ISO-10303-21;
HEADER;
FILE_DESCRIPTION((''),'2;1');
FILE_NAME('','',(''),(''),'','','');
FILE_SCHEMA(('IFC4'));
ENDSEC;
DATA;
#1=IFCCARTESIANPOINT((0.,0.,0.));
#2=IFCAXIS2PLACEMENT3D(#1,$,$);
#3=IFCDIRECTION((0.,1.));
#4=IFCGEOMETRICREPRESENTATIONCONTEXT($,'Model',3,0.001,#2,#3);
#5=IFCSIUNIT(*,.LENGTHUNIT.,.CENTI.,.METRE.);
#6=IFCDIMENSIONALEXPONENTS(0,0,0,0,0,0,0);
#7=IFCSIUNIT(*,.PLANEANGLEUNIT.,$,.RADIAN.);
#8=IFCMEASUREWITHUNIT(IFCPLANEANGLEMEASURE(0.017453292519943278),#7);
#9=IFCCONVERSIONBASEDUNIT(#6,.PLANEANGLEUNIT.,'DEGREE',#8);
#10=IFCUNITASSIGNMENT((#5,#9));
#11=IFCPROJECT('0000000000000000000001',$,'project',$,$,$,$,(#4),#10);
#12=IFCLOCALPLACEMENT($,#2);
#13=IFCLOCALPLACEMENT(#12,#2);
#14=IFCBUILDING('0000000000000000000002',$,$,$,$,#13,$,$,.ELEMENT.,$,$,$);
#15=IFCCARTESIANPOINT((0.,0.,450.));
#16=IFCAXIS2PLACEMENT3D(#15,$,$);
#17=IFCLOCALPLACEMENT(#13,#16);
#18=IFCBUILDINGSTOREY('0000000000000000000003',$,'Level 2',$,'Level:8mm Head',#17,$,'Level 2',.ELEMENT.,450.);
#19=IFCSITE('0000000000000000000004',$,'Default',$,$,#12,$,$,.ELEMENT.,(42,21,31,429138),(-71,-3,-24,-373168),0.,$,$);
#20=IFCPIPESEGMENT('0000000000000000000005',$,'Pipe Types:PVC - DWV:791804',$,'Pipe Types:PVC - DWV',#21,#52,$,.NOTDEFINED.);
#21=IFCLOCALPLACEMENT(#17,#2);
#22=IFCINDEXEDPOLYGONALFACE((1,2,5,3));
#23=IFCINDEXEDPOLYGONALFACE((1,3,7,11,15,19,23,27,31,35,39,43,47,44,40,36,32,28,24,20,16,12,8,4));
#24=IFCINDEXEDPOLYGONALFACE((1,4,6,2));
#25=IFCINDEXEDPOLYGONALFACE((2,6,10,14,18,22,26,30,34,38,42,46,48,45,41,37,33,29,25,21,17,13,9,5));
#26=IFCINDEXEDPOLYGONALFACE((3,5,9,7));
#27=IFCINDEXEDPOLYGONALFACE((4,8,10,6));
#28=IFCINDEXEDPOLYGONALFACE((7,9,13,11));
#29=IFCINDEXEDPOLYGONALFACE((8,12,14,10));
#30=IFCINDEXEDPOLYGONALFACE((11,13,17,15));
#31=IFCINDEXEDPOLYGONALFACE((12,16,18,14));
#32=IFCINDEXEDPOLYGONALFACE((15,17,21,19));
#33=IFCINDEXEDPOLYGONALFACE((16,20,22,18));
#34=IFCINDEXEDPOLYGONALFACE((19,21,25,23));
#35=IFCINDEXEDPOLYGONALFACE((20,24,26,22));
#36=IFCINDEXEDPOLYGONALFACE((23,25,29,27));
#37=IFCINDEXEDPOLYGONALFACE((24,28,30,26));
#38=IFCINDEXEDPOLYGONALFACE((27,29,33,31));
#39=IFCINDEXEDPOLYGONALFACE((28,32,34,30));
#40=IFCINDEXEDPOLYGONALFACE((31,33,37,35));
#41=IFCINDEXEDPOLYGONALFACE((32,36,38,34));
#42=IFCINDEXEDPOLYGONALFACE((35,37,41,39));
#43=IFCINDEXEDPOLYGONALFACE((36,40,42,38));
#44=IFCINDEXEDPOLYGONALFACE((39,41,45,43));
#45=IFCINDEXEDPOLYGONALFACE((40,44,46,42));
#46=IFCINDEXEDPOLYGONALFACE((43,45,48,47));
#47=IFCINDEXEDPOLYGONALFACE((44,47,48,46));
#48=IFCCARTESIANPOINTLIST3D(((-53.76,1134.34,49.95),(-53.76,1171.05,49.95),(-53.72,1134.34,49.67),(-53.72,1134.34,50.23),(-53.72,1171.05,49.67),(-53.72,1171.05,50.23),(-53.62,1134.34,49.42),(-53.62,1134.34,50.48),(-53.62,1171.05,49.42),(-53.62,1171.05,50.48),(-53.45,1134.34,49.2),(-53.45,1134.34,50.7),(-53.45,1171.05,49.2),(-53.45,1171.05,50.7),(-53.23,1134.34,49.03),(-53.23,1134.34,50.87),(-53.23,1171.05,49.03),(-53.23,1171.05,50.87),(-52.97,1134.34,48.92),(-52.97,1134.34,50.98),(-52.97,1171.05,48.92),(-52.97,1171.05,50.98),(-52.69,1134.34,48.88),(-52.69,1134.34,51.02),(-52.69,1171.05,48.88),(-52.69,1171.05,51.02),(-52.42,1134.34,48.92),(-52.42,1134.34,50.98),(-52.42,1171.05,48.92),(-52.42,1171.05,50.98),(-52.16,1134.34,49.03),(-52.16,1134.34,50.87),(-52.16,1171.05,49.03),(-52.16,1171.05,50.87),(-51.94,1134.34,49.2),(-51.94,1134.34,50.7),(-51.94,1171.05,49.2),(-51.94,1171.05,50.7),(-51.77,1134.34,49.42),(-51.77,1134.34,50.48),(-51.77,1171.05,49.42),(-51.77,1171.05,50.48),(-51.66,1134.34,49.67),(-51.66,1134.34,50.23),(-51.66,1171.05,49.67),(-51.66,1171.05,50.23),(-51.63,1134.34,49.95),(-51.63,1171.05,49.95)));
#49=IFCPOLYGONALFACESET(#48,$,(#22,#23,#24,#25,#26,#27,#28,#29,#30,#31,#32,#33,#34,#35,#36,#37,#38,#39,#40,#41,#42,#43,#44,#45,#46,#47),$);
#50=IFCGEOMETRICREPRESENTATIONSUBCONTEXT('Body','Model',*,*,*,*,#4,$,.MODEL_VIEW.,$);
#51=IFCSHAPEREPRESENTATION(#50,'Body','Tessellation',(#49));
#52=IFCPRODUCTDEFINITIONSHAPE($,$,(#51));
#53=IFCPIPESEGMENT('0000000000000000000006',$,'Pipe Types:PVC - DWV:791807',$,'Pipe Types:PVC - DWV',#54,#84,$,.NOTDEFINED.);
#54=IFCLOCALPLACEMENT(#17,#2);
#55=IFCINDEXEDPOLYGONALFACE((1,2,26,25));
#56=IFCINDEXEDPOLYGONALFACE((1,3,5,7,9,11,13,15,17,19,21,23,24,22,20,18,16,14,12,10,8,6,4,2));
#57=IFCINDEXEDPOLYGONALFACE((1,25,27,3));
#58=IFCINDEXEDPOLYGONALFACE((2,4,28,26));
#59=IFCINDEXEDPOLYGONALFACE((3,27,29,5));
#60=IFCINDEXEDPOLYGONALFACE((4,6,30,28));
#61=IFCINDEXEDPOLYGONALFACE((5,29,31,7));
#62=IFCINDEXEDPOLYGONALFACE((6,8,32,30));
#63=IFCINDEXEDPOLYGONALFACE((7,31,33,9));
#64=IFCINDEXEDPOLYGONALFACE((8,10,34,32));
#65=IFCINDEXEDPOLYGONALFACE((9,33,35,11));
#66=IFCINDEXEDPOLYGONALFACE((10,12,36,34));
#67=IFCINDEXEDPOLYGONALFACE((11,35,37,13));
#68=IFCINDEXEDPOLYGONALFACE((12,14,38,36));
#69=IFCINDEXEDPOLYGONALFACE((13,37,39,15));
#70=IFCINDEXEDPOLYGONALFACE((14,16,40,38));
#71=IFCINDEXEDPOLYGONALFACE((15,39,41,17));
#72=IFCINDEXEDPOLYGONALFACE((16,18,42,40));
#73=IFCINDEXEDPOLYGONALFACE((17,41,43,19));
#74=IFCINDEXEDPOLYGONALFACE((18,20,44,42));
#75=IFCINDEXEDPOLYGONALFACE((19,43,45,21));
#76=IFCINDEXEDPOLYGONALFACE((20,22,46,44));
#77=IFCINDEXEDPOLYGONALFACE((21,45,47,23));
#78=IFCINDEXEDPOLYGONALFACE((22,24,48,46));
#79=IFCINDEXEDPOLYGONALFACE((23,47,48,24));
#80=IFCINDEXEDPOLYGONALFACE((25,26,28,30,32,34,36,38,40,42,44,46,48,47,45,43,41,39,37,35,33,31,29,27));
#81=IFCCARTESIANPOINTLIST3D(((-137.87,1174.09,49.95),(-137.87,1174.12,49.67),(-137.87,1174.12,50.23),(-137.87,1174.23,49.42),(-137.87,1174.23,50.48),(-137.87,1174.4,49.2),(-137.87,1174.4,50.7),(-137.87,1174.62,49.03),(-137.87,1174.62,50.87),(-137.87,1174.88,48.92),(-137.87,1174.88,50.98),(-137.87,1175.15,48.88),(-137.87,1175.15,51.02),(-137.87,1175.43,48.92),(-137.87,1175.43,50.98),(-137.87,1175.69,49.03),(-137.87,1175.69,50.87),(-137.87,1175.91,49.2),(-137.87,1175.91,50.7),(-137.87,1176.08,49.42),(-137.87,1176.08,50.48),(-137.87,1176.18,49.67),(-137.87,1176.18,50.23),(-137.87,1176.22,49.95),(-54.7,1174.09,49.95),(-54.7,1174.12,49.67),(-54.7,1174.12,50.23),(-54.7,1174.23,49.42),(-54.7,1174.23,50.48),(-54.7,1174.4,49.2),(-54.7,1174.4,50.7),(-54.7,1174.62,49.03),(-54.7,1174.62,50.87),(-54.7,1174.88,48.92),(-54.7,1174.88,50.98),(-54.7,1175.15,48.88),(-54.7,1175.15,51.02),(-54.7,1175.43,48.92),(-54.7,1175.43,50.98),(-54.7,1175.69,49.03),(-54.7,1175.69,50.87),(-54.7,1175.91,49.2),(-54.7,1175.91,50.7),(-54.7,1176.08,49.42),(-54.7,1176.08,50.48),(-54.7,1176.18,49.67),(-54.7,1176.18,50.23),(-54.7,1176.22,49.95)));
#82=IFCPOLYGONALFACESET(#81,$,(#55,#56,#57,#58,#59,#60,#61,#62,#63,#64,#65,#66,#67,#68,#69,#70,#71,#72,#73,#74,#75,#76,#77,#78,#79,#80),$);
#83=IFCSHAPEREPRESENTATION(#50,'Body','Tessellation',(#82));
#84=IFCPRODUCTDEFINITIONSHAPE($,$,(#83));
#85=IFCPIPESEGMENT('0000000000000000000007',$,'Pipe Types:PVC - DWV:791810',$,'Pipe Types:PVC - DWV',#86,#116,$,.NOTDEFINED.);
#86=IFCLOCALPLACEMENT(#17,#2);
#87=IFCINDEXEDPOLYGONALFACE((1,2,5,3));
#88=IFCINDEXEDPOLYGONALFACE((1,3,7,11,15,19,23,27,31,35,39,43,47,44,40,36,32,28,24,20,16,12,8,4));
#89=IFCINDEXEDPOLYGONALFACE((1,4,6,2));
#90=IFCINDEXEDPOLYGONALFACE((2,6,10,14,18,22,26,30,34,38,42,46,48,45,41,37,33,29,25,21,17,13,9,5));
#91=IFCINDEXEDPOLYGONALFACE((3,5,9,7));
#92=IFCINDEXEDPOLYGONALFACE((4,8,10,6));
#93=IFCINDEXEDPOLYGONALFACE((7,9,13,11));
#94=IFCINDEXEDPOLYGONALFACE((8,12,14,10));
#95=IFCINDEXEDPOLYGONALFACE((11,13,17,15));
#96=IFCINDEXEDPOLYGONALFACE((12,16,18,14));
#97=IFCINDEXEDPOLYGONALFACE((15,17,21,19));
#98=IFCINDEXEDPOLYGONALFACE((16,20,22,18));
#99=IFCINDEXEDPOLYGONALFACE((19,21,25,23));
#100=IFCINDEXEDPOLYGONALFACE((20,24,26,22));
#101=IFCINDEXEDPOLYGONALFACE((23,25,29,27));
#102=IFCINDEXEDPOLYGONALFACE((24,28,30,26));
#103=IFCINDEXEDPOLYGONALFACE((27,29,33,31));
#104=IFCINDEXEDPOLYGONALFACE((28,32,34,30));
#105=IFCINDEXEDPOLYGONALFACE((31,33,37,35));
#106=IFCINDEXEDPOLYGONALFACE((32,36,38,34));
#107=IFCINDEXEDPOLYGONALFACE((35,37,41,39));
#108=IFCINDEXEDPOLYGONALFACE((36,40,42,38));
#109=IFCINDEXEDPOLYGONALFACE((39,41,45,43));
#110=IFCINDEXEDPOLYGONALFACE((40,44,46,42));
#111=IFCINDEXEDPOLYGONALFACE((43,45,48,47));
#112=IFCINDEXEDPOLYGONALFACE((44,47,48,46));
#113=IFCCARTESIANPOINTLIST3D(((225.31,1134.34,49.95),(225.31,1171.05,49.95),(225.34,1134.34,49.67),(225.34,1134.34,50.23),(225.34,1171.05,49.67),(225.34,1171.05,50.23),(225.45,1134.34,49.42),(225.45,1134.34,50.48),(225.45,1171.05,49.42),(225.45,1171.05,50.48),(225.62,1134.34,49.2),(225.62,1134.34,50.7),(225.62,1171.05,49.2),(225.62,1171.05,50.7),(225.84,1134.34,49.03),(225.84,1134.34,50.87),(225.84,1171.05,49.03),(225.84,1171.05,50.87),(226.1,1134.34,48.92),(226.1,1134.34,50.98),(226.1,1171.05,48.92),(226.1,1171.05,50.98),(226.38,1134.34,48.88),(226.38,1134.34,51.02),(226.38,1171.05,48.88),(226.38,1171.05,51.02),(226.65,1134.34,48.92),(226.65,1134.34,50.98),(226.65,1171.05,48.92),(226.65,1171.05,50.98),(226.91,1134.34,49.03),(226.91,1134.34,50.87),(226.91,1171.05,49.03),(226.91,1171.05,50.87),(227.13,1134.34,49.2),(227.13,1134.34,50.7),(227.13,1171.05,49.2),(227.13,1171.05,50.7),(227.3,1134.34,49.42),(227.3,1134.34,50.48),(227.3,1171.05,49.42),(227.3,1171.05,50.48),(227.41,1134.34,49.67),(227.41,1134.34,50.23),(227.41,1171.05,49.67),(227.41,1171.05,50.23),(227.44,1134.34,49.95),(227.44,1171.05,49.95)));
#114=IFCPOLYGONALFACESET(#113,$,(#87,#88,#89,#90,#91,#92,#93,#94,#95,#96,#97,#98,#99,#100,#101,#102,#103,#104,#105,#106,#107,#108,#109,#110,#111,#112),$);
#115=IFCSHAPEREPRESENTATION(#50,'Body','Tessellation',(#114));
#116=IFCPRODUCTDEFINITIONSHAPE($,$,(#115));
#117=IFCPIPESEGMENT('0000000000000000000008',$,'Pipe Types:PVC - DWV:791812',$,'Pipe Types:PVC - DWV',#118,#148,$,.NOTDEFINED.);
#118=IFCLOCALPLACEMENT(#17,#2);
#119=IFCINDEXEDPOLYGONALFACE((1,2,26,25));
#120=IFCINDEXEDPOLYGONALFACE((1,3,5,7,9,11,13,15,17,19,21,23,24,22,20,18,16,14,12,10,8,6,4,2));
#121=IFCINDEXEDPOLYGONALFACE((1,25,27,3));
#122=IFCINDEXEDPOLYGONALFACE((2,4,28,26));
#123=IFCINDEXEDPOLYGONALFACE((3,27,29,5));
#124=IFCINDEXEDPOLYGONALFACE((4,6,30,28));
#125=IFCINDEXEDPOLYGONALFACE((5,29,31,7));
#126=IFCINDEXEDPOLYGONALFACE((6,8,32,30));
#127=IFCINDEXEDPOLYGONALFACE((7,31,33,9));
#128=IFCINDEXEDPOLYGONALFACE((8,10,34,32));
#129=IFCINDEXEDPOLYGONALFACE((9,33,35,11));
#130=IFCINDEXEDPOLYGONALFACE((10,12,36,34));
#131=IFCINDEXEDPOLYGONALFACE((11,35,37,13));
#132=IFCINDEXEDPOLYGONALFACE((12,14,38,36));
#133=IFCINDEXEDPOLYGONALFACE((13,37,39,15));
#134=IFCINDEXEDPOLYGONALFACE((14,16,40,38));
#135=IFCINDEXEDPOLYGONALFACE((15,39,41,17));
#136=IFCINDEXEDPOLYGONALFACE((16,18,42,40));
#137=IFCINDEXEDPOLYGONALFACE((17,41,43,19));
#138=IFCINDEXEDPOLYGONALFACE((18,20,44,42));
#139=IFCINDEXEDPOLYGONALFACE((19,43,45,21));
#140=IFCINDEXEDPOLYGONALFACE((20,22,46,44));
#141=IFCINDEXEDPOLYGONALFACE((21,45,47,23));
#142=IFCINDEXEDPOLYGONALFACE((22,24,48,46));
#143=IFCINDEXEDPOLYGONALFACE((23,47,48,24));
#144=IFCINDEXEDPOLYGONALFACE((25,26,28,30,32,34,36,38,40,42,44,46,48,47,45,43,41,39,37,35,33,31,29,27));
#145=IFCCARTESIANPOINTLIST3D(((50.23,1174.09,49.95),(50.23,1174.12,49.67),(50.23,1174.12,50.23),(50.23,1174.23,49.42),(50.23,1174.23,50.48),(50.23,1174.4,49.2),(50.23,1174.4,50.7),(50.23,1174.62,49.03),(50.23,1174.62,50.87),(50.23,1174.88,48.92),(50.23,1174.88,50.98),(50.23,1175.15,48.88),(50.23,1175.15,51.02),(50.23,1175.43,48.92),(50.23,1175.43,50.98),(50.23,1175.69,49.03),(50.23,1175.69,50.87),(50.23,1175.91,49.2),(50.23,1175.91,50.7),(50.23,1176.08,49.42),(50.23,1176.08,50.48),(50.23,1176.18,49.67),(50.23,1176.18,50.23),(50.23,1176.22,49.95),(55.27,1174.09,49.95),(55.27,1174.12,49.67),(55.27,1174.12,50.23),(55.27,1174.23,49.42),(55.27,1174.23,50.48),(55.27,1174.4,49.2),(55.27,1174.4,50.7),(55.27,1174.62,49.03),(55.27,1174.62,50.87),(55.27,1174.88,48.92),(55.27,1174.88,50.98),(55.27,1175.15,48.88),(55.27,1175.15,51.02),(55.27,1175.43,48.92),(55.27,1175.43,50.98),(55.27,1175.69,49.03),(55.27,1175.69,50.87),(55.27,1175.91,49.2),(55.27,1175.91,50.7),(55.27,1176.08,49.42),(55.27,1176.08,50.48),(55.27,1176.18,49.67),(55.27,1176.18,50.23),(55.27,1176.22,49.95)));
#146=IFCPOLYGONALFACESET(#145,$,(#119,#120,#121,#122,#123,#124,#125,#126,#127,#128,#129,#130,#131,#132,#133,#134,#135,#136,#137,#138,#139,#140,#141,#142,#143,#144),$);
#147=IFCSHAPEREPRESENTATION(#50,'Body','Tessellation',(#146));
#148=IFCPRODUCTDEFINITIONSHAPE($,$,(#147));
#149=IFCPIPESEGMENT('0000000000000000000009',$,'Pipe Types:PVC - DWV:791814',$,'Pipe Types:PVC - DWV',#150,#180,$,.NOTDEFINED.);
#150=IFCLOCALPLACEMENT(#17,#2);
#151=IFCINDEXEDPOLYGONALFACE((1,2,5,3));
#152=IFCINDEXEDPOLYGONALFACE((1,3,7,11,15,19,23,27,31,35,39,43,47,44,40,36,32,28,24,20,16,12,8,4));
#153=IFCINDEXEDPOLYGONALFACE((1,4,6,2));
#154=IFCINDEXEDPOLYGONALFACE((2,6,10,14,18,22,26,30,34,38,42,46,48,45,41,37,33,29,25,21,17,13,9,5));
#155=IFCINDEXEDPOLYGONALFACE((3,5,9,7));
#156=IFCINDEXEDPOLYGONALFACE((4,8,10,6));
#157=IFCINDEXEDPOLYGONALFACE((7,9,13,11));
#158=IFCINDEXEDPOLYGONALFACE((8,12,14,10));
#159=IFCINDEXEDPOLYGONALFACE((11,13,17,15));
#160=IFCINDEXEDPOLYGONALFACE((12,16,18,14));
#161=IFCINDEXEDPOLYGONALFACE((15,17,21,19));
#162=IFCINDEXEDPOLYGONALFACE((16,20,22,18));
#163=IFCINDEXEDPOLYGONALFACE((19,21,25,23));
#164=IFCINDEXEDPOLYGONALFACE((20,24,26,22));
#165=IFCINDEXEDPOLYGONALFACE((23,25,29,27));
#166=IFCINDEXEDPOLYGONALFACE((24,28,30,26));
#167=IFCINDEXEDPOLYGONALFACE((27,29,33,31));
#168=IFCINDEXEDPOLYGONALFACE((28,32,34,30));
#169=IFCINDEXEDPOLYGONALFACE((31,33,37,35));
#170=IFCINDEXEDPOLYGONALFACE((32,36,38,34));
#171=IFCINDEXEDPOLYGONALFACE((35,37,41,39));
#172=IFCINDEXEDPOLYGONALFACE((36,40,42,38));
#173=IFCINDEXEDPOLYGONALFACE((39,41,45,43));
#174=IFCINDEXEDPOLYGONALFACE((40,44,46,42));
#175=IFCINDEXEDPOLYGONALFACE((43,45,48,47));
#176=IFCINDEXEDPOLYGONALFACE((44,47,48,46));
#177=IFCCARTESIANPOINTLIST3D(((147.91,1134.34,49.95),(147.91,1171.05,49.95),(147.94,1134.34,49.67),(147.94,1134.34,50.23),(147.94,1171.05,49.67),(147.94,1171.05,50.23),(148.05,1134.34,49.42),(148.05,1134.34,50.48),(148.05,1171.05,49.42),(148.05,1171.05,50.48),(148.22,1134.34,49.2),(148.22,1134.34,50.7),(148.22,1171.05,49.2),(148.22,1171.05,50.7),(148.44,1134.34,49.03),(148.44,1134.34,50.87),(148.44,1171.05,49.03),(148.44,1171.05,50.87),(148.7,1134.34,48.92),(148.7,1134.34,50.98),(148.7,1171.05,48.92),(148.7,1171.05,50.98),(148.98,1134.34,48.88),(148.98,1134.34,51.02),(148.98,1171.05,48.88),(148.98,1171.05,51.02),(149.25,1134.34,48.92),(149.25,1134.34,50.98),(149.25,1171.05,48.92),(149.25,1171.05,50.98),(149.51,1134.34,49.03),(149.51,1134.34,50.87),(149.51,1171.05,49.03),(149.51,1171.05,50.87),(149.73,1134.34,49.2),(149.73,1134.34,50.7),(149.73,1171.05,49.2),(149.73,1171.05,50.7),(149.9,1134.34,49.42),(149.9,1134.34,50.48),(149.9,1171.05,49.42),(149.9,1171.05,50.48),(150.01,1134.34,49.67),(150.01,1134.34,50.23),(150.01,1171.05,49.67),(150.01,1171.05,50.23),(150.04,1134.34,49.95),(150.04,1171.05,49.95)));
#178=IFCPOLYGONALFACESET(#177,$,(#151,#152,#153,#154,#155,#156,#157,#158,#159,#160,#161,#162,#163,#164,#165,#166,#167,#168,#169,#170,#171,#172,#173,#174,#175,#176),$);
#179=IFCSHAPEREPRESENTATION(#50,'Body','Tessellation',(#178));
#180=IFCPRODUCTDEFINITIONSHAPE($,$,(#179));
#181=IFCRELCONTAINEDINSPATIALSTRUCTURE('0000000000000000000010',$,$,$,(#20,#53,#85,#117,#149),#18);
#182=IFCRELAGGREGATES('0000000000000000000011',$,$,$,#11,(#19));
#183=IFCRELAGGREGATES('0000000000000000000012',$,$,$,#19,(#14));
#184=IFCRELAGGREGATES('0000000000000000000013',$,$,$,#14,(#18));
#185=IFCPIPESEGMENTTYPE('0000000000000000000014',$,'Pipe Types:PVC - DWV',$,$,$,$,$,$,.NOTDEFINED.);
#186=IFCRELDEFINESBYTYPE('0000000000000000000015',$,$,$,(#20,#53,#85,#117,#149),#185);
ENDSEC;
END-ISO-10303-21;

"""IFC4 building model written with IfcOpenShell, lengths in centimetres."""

from ifc_helpers import new_model, entity, si_unit, converted_unit, direction, frame, origin, place, context, subcontext, project, spatial, arc, indexed_curve, outline, extrude, type_object, element, save


model = new_model("IFC4")

# Units and contexts
model_context = context("Model", 3, precision=0.001, world=origin(), true_north=direction((0.0, 1.0)))
body_context = subcontext(model_context, "Body", "Model", "MODEL_VIEW")
ifc_project = project(units=[si_unit("LENGTHUNIT", "METRE", prefix="CENTI"), converted_unit("PLANEANGLEUNIT", "DEGREE", entity("IfcPlaneAngleMeasure", 0.017453292519943278), si_unit("PLANEANGLEUNIT", "RADIAN"), dimensions=[0, 0, 0, 0, 0, 0, 0])], contexts=[model_context])

# Site, building, storey
site_placement = place(None, origin())
site = spatial("IfcSite", under=ifc_project, at=site_placement, Name="Default", CompositionType="ELEMENT", RefLatitude=(42, 21, 31, 429138), RefLongitude=(-71, -3, -24, -373168), RefElevation=0.0)
building_placement = place(site_placement, origin())
building = spatial("IfcBuilding", under=site, at=building_placement, CompositionType="ELEMENT")
storey_placement = place(building_placement, frame((0.0, 0.0, 450.0)))
storey = spatial("IfcBuildingStorey", under=building, at=storey_placement, Name="Level 2", ObjectType="Level:8mm Head", LongName="Level 2", CompositionType="ELEMENT", Elevation=450.0)

# Pipe segments
pipe_segment_type = type_object("IfcPipeSegmentType", Name="Pipe Types:PVC - DWV", PredefinedType="NOTDEFINED")
pipe_segment_1_placement = place(storey_placement, origin())
element("IfcPipeSegment", 1, at=pipe_segment_1_placement, inside=storey, type_object=pipe_segment_type, Name="Pipe Types:PVC - DWV:791804", ObjectType="Pipe Types:PVC - DWV", PredefinedType="NOTDEFINED", context=body_context, shape_type="SweptSolid", body=[
    extrude(outline(indexed_curve([(1.07, 0.0), (0.75, 0.75), (0.0, 1.07), (-0.75, 0.75), (-1.07, 0.0), (-0.75, -0.75), (0.0, -1.07), (0.75, -0.75)], segments=[arc(1, 2, 3), arc(3, 4, 5), arc(5, 6, 7), arc(7, 8, 1)], self_intersect=False)), frame((-52.69, 1134.34, 49.95), z_axis=(0.0, 1.0, 0.0), x_axis=(-1.0, 0.0, 0.0)), (0.0, 0.0, 1.0), 36.71),
])
pipe_segment_2_placement = place(storey_placement, origin())
element("IfcPipeSegment", 2, at=pipe_segment_2_placement, inside=storey, type_object=pipe_segment_type, Name="Pipe Types:PVC - DWV:791807", ObjectType="Pipe Types:PVC - DWV", PredefinedType="NOTDEFINED", context=body_context, shape_type="SweptSolid", body=[
    extrude(outline(indexed_curve([(1.07, 0.0), (0.75, 0.75), (0.0, 1.07), (-0.75, 0.75), (-1.07, 0.0), (-0.75, -0.75), (0.0, -1.07), (0.75, -0.75)], segments=[arc(1, 2, 3), arc(3, 4, 5), arc(5, 6, 7), arc(7, 8, 1)], self_intersect=False)), frame((-137.87, 1175.15, 49.95), z_axis=(1.0, 0.0, 0.0), x_axis=(0.0, -1.0, 0.0)), (0.0, 0.0, 1.0), 83.17),
])
pipe_segment_3_placement = place(storey_placement, origin())
element("IfcPipeSegment", 3, at=pipe_segment_3_placement, inside=storey, type_object=pipe_segment_type, Name="Pipe Types:PVC - DWV:791810", ObjectType="Pipe Types:PVC - DWV", PredefinedType="NOTDEFINED", context=body_context, shape_type="SweptSolid", body=[
    extrude(outline(indexed_curve([(1.07, 0.0), (0.75, 0.75), (0.0, 1.07), (-0.75, 0.75), (-1.07, 0.0), (-0.75, -0.75), (0.0, -1.07), (0.75, -0.75)], segments=[arc(1, 2, 3), arc(3, 4, 5), arc(5, 6, 7), arc(7, 8, 1)], self_intersect=False)), frame((226.38, 1134.34, 49.95), z_axis=(0.0, 1.0, 0.0), x_axis=(-1.0, 0.0, 0.0)), (0.0, 0.0, 1.0), 36.71),
])
pipe_segment_4_placement = place(storey_placement, origin())
element("IfcPipeSegment", 4, at=pipe_segment_4_placement, inside=storey, type_object=pipe_segment_type, Name="Pipe Types:PVC - DWV:791812", ObjectType="Pipe Types:PVC - DWV", PredefinedType="NOTDEFINED", context=body_context, shape_type="SweptSolid", body=[
    extrude(outline(indexed_curve([(1.07, 0.0), (0.75, 0.75), (0.0, 1.07), (-0.75, 0.75), (-1.07, 0.0), (-0.75, -0.75), (0.0, -1.07), (0.75, -0.75)], segments=[arc(1, 2, 3), arc(3, 4, 5), arc(5, 6, 7), arc(7, 8, 1)], self_intersect=False)), frame((50.23, 1175.15, 49.95), z_axis=(1.0, 0.0, 0.0), x_axis=(0.0, 1.0, 0.0)), (0.0, 0.0, 1.0), 5.04),
])
pipe_segment_5_placement = place(storey_placement, origin())
element("IfcPipeSegment", 5, at=pipe_segment_5_placement, inside=storey, type_object=pipe_segment_type, Name="Pipe Types:PVC - DWV:791814", ObjectType="Pipe Types:PVC - DWV", PredefinedType="NOTDEFINED", context=body_context, shape_type="SweptSolid", body=[
    extrude(outline(indexed_curve([(1.07, 0.0), (0.75, 0.75), (0.0, 1.07), (-0.75, 0.75), (-1.07, 0.0), (-0.75, -0.75), (0.0, -1.07), (0.75, -0.75)], segments=[arc(1, 2, 3), arc(3, 4, 5), arc(5, 6, 7), arc(7, 8, 1)], self_intersect=False)), frame((148.98, 1134.34, 49.95), z_axis=(0.0, 1.0, 0.0), x_axis=(-1.0, 0.0, 0.0)), (0.0, 0.0, 1.0), 36.71),
])

save(model, "model.ifc")
